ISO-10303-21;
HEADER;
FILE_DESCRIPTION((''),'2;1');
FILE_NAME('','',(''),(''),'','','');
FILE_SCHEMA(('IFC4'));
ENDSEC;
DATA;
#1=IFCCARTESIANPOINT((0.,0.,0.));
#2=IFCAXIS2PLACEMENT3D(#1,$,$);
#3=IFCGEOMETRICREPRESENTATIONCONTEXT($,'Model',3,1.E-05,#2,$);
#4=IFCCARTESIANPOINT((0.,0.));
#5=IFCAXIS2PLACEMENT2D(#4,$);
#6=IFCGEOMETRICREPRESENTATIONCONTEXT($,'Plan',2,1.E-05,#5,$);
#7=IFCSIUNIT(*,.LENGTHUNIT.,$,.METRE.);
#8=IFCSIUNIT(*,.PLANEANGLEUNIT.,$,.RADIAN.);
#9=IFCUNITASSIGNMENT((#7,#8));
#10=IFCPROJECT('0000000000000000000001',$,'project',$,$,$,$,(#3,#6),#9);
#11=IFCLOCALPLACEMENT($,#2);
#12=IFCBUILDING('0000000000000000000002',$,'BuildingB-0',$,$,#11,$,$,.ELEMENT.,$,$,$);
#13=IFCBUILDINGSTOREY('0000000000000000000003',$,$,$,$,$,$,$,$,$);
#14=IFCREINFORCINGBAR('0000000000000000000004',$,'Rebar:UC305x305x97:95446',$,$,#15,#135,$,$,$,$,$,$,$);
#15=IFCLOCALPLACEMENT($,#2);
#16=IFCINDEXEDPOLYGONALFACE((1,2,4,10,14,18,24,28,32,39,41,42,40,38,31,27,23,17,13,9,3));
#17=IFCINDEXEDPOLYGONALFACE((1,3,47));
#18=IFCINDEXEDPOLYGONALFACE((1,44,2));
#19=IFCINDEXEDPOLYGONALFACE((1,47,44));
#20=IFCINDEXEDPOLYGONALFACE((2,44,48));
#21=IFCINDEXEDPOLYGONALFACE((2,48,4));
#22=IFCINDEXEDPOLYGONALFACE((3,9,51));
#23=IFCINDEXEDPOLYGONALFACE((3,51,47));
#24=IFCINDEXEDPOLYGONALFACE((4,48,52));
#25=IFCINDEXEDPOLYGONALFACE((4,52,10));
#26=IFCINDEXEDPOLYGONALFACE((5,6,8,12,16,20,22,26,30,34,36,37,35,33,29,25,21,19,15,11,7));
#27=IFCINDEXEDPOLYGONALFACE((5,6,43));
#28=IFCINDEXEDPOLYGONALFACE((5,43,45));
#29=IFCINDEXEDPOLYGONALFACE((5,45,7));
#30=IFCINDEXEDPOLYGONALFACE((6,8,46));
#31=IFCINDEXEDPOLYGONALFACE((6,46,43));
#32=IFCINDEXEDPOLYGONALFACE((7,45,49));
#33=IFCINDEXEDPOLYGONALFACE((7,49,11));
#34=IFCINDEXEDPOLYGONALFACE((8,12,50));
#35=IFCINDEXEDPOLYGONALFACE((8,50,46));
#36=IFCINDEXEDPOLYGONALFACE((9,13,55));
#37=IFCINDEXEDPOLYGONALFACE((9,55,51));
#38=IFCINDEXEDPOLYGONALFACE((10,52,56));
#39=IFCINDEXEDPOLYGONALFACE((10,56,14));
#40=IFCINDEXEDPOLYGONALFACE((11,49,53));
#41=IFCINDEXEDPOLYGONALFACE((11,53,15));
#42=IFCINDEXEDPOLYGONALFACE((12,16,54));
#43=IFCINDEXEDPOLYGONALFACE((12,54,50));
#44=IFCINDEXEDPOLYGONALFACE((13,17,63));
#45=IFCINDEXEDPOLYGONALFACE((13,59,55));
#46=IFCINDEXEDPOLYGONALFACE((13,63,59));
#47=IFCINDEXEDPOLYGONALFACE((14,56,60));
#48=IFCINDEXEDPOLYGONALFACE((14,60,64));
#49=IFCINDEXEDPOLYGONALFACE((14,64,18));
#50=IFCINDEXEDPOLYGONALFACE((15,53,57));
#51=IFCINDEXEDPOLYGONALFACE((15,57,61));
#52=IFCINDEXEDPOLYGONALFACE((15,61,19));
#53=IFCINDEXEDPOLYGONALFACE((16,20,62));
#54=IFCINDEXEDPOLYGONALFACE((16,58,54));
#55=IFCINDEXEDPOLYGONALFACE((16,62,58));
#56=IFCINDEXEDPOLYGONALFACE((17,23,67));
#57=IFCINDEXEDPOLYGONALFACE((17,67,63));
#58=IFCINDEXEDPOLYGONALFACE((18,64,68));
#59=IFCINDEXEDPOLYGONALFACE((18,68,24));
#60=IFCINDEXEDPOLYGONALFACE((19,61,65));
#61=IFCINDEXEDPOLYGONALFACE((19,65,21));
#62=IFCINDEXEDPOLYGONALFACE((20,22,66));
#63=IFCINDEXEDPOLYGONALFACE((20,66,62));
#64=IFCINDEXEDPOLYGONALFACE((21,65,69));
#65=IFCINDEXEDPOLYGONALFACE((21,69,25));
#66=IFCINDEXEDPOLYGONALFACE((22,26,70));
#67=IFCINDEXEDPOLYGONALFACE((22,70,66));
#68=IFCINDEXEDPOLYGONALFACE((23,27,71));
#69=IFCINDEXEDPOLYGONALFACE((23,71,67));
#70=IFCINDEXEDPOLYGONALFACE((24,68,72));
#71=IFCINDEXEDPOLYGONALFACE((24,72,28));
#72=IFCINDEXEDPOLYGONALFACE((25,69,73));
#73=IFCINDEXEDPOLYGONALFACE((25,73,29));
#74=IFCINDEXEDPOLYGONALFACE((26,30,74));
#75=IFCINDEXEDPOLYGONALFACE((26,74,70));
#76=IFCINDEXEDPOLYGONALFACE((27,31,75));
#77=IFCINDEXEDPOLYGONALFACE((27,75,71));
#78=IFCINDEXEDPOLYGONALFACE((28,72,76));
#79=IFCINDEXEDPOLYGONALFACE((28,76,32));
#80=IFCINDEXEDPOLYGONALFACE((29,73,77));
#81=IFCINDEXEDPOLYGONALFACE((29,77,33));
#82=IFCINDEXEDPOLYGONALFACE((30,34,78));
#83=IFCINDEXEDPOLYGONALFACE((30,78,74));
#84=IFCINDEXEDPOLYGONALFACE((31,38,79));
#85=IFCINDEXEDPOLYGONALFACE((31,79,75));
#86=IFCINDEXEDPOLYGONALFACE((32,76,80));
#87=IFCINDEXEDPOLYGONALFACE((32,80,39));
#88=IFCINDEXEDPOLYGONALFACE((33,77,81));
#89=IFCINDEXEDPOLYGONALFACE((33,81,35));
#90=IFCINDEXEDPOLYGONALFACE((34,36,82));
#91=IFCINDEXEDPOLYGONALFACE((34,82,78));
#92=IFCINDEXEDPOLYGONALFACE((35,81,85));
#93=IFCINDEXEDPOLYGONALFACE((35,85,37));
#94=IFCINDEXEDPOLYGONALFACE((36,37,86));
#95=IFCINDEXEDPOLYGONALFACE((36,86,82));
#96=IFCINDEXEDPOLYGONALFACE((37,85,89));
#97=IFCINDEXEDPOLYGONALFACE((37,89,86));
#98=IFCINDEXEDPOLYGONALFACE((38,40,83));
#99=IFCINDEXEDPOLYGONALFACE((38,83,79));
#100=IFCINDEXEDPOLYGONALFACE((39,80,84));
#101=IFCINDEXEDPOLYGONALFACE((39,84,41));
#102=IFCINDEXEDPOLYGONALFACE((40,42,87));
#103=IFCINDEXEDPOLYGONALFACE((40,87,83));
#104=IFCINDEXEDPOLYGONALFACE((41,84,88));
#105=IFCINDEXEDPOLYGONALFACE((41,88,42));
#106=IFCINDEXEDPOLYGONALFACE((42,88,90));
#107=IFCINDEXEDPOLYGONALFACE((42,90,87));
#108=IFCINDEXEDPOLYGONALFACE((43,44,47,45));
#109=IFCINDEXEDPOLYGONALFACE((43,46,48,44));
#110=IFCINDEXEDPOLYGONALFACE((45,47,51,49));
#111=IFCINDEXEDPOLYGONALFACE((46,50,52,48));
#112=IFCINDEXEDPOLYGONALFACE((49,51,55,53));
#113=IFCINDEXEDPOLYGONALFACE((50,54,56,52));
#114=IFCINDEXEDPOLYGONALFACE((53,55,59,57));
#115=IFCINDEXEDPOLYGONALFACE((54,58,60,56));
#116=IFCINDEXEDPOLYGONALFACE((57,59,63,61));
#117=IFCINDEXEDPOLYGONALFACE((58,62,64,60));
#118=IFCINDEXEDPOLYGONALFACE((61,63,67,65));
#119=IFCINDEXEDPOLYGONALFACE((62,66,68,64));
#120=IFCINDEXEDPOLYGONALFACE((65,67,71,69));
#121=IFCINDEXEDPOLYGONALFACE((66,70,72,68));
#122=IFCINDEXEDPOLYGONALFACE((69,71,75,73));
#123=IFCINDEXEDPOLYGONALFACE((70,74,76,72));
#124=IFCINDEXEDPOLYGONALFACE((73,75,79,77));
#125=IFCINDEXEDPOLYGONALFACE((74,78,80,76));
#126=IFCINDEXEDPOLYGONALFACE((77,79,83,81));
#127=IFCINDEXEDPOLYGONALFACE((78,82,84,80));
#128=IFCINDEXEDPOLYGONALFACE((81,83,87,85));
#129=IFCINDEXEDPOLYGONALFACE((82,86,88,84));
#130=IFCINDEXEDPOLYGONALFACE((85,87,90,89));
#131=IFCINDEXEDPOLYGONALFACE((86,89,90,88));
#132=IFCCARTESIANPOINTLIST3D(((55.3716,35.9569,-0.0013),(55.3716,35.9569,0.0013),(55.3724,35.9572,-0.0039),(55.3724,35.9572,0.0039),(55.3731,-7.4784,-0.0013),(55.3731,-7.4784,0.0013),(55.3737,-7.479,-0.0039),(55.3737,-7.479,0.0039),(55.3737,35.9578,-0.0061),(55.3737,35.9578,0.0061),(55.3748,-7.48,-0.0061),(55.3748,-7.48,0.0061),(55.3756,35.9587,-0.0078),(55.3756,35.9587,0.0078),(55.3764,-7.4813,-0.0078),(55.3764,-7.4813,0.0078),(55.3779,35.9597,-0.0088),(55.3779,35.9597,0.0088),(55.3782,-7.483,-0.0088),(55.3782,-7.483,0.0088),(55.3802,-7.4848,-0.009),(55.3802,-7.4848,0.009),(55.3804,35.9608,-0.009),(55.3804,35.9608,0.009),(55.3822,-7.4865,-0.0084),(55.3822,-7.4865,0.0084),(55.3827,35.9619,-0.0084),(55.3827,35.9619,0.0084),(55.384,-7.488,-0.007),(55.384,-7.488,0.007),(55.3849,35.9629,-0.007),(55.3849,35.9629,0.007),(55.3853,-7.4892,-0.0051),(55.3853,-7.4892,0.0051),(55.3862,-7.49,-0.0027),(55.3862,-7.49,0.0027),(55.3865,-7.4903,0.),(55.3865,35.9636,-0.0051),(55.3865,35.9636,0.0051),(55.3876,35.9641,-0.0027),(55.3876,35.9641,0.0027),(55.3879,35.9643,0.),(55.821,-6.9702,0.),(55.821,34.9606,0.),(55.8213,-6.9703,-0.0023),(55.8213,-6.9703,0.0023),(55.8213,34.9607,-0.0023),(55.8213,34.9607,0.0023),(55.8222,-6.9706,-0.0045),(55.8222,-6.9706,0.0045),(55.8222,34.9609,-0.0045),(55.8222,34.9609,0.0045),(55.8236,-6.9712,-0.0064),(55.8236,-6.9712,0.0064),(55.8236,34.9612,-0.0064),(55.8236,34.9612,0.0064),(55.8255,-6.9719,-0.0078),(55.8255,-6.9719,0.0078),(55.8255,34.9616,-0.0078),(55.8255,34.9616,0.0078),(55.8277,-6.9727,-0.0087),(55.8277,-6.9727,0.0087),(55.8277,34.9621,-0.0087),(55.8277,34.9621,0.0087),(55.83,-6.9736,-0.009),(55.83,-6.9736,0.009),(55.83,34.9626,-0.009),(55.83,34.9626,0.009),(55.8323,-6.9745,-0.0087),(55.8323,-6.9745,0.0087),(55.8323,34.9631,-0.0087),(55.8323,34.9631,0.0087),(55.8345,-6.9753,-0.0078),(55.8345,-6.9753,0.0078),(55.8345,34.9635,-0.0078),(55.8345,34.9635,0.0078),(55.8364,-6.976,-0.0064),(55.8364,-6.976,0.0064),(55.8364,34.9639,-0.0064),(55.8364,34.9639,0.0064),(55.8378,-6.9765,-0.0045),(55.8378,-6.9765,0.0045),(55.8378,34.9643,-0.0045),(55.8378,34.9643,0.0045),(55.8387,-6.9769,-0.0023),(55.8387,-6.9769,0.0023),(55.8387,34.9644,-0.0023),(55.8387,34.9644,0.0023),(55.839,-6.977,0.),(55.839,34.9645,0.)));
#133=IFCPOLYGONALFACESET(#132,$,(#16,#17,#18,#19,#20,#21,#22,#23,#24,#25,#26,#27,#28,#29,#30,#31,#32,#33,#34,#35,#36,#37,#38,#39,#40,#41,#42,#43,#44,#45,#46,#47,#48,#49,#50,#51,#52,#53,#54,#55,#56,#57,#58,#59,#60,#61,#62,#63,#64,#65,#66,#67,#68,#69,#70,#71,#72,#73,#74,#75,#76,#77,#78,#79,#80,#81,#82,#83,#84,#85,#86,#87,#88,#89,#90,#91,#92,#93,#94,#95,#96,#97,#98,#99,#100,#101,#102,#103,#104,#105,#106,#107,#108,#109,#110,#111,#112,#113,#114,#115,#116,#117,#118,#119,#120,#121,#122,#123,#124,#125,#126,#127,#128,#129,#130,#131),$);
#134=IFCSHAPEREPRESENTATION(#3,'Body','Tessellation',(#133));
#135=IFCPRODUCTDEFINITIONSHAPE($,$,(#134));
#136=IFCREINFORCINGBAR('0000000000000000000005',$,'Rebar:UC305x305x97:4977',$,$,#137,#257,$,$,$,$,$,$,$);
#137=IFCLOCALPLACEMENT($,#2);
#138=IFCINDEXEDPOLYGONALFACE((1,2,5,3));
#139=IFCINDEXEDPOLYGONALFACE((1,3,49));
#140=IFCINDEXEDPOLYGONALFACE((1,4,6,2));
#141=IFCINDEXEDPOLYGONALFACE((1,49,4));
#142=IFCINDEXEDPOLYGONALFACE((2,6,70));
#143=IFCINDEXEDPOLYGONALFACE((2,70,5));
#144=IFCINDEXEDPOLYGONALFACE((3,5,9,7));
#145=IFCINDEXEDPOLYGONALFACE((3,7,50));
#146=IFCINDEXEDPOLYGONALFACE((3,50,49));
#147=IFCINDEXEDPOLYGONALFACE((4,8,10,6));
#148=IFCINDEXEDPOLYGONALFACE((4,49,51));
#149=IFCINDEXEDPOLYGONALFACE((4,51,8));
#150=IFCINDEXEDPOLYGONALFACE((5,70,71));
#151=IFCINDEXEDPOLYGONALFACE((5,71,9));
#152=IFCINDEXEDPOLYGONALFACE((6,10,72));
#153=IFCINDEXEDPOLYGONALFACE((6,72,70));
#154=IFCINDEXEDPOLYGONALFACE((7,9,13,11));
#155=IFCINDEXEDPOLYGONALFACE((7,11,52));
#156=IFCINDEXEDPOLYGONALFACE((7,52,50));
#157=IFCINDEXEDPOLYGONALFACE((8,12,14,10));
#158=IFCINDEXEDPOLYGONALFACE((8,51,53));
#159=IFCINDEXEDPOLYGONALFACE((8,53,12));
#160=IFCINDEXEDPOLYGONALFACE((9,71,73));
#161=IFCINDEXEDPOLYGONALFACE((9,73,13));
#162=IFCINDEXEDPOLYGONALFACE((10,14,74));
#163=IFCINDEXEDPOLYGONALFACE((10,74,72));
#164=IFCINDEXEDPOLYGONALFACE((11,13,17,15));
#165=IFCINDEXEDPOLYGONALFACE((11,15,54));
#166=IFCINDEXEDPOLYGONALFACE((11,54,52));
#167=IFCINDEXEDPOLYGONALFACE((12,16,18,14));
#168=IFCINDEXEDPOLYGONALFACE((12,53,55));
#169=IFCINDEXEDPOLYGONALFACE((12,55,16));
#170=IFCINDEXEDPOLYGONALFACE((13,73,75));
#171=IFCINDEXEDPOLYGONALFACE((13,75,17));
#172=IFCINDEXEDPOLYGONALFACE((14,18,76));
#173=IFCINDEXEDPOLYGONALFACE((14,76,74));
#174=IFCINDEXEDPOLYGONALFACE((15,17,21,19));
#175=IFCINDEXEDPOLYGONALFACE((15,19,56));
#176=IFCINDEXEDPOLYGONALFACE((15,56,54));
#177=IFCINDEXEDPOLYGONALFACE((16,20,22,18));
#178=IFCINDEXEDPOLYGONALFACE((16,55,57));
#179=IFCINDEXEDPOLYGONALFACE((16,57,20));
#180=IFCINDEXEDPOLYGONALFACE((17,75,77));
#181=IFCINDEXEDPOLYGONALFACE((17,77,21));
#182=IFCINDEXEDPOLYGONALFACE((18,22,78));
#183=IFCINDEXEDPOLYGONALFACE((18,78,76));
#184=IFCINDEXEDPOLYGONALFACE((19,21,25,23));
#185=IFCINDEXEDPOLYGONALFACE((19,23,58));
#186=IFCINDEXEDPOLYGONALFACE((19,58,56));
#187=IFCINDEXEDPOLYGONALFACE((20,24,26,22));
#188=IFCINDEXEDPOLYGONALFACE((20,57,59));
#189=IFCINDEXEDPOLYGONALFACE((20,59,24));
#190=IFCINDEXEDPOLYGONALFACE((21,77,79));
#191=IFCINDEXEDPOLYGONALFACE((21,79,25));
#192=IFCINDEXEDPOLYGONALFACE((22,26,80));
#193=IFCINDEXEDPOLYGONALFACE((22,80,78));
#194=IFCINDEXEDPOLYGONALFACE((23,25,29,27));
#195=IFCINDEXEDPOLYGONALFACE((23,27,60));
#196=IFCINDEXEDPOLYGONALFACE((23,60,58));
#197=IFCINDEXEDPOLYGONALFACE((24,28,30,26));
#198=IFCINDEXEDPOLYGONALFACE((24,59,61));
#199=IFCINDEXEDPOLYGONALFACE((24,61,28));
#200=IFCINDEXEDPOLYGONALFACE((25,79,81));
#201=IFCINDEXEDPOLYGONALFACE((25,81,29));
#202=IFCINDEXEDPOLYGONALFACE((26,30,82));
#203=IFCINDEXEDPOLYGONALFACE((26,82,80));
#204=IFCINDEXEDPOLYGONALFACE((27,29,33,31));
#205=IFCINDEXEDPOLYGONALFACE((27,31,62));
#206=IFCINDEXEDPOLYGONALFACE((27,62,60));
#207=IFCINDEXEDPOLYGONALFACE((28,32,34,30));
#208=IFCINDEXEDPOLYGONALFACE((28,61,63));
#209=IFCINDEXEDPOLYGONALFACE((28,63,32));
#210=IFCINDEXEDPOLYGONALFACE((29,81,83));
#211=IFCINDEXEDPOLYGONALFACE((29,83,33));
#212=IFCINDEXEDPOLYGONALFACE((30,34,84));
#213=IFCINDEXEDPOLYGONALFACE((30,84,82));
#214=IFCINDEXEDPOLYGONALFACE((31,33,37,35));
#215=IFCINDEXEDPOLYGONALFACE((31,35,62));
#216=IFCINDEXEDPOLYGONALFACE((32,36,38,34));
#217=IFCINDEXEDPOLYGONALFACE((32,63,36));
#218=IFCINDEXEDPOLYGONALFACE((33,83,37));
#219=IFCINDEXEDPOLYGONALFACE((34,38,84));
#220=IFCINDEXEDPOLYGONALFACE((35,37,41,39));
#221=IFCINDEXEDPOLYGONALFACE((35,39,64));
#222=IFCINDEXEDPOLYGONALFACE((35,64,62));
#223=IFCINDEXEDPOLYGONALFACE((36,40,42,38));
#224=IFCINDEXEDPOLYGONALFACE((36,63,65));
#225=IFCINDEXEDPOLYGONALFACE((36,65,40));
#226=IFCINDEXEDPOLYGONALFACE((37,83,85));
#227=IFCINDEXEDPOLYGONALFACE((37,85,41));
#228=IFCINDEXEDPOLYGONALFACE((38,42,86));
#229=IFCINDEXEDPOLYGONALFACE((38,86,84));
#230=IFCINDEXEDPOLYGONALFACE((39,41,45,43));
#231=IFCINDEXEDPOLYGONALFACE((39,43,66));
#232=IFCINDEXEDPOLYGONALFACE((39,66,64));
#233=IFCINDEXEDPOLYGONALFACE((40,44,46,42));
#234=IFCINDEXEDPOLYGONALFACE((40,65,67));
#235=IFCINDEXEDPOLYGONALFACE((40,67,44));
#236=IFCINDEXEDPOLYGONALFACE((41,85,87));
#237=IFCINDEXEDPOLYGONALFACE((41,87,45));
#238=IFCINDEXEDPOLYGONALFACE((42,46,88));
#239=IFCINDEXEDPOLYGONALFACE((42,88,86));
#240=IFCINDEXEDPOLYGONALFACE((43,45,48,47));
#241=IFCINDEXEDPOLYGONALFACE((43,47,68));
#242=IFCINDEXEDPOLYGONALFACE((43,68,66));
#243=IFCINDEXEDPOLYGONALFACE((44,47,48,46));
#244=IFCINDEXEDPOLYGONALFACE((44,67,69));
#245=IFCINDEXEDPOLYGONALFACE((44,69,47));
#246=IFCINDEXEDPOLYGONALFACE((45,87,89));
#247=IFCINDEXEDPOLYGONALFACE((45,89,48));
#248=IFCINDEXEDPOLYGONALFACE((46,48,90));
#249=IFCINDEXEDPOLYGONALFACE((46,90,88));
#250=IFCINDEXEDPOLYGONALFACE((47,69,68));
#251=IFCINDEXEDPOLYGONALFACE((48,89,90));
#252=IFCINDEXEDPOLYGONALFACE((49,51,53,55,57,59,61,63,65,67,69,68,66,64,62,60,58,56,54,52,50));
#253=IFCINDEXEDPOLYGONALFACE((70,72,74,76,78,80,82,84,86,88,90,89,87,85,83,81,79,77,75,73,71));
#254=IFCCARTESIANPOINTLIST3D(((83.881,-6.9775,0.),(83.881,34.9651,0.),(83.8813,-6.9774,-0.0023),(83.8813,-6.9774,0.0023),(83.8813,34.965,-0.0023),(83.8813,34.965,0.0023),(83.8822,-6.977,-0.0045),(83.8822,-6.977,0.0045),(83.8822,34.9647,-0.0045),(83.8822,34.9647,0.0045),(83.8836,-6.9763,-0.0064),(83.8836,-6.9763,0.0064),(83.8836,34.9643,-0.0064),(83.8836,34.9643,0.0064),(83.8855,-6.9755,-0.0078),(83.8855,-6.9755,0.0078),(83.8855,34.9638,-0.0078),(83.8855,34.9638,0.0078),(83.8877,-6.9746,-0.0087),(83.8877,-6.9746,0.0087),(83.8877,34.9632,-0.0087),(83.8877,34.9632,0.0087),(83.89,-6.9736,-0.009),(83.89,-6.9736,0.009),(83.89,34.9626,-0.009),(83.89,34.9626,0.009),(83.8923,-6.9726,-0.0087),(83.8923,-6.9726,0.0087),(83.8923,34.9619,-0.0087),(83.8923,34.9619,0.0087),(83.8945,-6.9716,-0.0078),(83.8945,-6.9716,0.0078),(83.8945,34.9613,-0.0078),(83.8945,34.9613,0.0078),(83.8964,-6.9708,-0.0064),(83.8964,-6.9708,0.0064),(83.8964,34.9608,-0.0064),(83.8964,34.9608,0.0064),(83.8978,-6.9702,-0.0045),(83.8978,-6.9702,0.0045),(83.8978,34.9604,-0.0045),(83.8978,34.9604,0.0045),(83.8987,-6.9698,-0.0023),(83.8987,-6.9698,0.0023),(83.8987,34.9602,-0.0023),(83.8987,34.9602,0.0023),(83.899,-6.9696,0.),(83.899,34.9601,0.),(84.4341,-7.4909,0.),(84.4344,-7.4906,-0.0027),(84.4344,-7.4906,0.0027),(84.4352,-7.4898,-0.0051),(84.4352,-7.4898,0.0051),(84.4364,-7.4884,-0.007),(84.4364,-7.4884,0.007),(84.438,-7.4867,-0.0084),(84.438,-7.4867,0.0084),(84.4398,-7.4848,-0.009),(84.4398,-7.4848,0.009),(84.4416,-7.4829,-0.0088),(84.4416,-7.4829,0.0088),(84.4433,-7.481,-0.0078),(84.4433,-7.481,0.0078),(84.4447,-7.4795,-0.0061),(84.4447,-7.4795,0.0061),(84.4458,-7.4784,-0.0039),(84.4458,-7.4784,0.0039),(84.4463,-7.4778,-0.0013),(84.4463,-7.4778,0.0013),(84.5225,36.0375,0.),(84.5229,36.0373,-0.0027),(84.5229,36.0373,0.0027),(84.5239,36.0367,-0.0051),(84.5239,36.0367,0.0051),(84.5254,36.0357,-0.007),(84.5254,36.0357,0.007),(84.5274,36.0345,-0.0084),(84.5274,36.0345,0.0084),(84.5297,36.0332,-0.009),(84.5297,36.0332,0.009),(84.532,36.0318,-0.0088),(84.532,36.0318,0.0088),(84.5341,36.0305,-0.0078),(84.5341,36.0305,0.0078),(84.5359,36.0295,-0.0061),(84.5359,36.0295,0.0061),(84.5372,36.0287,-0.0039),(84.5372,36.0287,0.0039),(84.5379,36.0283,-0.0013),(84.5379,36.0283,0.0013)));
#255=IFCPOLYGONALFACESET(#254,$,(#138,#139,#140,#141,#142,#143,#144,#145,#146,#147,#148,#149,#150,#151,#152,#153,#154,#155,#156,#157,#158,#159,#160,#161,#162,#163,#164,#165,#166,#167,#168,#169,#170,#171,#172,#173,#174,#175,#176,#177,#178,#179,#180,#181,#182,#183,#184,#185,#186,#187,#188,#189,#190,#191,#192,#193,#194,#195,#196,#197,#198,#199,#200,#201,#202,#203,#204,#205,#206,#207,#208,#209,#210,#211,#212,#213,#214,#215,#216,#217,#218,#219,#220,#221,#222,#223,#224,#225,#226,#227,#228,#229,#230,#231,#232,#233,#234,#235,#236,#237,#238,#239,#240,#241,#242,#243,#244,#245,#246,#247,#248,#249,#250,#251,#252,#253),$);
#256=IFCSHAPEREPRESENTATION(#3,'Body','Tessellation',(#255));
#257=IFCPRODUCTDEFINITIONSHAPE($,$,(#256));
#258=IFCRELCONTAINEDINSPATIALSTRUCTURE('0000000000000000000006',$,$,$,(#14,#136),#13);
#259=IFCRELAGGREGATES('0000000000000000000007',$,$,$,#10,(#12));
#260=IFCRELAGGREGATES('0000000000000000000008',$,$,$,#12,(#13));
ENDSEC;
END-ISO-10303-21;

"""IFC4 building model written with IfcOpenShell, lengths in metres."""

from ifc_helpers import new_model, entity, si_unit, origin, origin_2d, place, context, project, spatial, element, save


model = new_model("IFC4")

# Units and contexts
model_context = context("Model", 3, precision=1e-05, world=origin())
plan_context = context("Plan", 2, precision=1e-05, world=origin_2d())
ifc_project = project(units=[si_unit("LENGTHUNIT", "METRE"), si_unit("PLANEANGLEUNIT", "RADIAN")], contexts=[model_context, plan_context])

# Building, storey
building_placement = place(None, origin())
building = spatial("IfcBuilding", under=ifc_project, at=building_placement, Name="BuildingB-0", CompositionType="ELEMENT")
storey = spatial("IfcBuildingStorey", under=building)

# Reinforcing bars
element("IfcReinforcingBar", 1, inside=storey, Name="Rebar:UC305x305x97:95446", context=model_context, shape_type="SweptSolid", body=[
    entity("IfcSurfaceCurveSweptAreaSolid", entity("IfcCircleProfileDef", "AREA", None, None, 0.009), None, entity("IfcPolyline", [entity("IfcCartesianPoint", [55.3797, -7.4843, 0.0]), entity("IfcCartesianPoint", [55.83, -6.9736, 0.0]), entity("IfcCartesianPoint", [55.83, 34.9626, 0.0]), entity("IfcCartesianPoint", [55.3797, 35.9606, 0.0])]), None, None, entity("IfcPlane", entity("IfcAxis2Placement3D", entity("IfcCartesianPoint", [55.3797, -7.4843, 0.0]), entity("IfcDirection", [1.0, -0.000167, 0.0]), entity("IfcDirection", [0.0, 1.0, 0.0])))),
])
element("IfcReinforcingBar", 2, inside=storey, Name="Rebar:UC305x305x97:4977", context=model_context, shape_type="SweptSolid", body=[
    entity("IfcSurfaceCurveSweptAreaSolid", entity("IfcCircleProfileDef", "AREA", None, None, 0.009), None, entity("IfcPolyline", [entity("IfcCartesianPoint", [84.4403, -7.4843, 0.0]), entity("IfcCartesianPoint", [83.89, -6.9736, 0.0]), entity("IfcCartesianPoint", [83.89, 34.9626, 0.0]), entity("IfcCartesianPoint", [84.5303, 36.0329, 0.0])]), None, None, entity("IfcPlane", entity("IfcAxis2Placement3D", entity("IfcCartesianPoint", [84.4403, -7.4843, 0.0]), entity("IfcDirection", [1.0, -0.000167, 0.0]), entity("IfcDirection", [0.0, 1.0, 0.0])))),
])

save(model, "model.ifc")
